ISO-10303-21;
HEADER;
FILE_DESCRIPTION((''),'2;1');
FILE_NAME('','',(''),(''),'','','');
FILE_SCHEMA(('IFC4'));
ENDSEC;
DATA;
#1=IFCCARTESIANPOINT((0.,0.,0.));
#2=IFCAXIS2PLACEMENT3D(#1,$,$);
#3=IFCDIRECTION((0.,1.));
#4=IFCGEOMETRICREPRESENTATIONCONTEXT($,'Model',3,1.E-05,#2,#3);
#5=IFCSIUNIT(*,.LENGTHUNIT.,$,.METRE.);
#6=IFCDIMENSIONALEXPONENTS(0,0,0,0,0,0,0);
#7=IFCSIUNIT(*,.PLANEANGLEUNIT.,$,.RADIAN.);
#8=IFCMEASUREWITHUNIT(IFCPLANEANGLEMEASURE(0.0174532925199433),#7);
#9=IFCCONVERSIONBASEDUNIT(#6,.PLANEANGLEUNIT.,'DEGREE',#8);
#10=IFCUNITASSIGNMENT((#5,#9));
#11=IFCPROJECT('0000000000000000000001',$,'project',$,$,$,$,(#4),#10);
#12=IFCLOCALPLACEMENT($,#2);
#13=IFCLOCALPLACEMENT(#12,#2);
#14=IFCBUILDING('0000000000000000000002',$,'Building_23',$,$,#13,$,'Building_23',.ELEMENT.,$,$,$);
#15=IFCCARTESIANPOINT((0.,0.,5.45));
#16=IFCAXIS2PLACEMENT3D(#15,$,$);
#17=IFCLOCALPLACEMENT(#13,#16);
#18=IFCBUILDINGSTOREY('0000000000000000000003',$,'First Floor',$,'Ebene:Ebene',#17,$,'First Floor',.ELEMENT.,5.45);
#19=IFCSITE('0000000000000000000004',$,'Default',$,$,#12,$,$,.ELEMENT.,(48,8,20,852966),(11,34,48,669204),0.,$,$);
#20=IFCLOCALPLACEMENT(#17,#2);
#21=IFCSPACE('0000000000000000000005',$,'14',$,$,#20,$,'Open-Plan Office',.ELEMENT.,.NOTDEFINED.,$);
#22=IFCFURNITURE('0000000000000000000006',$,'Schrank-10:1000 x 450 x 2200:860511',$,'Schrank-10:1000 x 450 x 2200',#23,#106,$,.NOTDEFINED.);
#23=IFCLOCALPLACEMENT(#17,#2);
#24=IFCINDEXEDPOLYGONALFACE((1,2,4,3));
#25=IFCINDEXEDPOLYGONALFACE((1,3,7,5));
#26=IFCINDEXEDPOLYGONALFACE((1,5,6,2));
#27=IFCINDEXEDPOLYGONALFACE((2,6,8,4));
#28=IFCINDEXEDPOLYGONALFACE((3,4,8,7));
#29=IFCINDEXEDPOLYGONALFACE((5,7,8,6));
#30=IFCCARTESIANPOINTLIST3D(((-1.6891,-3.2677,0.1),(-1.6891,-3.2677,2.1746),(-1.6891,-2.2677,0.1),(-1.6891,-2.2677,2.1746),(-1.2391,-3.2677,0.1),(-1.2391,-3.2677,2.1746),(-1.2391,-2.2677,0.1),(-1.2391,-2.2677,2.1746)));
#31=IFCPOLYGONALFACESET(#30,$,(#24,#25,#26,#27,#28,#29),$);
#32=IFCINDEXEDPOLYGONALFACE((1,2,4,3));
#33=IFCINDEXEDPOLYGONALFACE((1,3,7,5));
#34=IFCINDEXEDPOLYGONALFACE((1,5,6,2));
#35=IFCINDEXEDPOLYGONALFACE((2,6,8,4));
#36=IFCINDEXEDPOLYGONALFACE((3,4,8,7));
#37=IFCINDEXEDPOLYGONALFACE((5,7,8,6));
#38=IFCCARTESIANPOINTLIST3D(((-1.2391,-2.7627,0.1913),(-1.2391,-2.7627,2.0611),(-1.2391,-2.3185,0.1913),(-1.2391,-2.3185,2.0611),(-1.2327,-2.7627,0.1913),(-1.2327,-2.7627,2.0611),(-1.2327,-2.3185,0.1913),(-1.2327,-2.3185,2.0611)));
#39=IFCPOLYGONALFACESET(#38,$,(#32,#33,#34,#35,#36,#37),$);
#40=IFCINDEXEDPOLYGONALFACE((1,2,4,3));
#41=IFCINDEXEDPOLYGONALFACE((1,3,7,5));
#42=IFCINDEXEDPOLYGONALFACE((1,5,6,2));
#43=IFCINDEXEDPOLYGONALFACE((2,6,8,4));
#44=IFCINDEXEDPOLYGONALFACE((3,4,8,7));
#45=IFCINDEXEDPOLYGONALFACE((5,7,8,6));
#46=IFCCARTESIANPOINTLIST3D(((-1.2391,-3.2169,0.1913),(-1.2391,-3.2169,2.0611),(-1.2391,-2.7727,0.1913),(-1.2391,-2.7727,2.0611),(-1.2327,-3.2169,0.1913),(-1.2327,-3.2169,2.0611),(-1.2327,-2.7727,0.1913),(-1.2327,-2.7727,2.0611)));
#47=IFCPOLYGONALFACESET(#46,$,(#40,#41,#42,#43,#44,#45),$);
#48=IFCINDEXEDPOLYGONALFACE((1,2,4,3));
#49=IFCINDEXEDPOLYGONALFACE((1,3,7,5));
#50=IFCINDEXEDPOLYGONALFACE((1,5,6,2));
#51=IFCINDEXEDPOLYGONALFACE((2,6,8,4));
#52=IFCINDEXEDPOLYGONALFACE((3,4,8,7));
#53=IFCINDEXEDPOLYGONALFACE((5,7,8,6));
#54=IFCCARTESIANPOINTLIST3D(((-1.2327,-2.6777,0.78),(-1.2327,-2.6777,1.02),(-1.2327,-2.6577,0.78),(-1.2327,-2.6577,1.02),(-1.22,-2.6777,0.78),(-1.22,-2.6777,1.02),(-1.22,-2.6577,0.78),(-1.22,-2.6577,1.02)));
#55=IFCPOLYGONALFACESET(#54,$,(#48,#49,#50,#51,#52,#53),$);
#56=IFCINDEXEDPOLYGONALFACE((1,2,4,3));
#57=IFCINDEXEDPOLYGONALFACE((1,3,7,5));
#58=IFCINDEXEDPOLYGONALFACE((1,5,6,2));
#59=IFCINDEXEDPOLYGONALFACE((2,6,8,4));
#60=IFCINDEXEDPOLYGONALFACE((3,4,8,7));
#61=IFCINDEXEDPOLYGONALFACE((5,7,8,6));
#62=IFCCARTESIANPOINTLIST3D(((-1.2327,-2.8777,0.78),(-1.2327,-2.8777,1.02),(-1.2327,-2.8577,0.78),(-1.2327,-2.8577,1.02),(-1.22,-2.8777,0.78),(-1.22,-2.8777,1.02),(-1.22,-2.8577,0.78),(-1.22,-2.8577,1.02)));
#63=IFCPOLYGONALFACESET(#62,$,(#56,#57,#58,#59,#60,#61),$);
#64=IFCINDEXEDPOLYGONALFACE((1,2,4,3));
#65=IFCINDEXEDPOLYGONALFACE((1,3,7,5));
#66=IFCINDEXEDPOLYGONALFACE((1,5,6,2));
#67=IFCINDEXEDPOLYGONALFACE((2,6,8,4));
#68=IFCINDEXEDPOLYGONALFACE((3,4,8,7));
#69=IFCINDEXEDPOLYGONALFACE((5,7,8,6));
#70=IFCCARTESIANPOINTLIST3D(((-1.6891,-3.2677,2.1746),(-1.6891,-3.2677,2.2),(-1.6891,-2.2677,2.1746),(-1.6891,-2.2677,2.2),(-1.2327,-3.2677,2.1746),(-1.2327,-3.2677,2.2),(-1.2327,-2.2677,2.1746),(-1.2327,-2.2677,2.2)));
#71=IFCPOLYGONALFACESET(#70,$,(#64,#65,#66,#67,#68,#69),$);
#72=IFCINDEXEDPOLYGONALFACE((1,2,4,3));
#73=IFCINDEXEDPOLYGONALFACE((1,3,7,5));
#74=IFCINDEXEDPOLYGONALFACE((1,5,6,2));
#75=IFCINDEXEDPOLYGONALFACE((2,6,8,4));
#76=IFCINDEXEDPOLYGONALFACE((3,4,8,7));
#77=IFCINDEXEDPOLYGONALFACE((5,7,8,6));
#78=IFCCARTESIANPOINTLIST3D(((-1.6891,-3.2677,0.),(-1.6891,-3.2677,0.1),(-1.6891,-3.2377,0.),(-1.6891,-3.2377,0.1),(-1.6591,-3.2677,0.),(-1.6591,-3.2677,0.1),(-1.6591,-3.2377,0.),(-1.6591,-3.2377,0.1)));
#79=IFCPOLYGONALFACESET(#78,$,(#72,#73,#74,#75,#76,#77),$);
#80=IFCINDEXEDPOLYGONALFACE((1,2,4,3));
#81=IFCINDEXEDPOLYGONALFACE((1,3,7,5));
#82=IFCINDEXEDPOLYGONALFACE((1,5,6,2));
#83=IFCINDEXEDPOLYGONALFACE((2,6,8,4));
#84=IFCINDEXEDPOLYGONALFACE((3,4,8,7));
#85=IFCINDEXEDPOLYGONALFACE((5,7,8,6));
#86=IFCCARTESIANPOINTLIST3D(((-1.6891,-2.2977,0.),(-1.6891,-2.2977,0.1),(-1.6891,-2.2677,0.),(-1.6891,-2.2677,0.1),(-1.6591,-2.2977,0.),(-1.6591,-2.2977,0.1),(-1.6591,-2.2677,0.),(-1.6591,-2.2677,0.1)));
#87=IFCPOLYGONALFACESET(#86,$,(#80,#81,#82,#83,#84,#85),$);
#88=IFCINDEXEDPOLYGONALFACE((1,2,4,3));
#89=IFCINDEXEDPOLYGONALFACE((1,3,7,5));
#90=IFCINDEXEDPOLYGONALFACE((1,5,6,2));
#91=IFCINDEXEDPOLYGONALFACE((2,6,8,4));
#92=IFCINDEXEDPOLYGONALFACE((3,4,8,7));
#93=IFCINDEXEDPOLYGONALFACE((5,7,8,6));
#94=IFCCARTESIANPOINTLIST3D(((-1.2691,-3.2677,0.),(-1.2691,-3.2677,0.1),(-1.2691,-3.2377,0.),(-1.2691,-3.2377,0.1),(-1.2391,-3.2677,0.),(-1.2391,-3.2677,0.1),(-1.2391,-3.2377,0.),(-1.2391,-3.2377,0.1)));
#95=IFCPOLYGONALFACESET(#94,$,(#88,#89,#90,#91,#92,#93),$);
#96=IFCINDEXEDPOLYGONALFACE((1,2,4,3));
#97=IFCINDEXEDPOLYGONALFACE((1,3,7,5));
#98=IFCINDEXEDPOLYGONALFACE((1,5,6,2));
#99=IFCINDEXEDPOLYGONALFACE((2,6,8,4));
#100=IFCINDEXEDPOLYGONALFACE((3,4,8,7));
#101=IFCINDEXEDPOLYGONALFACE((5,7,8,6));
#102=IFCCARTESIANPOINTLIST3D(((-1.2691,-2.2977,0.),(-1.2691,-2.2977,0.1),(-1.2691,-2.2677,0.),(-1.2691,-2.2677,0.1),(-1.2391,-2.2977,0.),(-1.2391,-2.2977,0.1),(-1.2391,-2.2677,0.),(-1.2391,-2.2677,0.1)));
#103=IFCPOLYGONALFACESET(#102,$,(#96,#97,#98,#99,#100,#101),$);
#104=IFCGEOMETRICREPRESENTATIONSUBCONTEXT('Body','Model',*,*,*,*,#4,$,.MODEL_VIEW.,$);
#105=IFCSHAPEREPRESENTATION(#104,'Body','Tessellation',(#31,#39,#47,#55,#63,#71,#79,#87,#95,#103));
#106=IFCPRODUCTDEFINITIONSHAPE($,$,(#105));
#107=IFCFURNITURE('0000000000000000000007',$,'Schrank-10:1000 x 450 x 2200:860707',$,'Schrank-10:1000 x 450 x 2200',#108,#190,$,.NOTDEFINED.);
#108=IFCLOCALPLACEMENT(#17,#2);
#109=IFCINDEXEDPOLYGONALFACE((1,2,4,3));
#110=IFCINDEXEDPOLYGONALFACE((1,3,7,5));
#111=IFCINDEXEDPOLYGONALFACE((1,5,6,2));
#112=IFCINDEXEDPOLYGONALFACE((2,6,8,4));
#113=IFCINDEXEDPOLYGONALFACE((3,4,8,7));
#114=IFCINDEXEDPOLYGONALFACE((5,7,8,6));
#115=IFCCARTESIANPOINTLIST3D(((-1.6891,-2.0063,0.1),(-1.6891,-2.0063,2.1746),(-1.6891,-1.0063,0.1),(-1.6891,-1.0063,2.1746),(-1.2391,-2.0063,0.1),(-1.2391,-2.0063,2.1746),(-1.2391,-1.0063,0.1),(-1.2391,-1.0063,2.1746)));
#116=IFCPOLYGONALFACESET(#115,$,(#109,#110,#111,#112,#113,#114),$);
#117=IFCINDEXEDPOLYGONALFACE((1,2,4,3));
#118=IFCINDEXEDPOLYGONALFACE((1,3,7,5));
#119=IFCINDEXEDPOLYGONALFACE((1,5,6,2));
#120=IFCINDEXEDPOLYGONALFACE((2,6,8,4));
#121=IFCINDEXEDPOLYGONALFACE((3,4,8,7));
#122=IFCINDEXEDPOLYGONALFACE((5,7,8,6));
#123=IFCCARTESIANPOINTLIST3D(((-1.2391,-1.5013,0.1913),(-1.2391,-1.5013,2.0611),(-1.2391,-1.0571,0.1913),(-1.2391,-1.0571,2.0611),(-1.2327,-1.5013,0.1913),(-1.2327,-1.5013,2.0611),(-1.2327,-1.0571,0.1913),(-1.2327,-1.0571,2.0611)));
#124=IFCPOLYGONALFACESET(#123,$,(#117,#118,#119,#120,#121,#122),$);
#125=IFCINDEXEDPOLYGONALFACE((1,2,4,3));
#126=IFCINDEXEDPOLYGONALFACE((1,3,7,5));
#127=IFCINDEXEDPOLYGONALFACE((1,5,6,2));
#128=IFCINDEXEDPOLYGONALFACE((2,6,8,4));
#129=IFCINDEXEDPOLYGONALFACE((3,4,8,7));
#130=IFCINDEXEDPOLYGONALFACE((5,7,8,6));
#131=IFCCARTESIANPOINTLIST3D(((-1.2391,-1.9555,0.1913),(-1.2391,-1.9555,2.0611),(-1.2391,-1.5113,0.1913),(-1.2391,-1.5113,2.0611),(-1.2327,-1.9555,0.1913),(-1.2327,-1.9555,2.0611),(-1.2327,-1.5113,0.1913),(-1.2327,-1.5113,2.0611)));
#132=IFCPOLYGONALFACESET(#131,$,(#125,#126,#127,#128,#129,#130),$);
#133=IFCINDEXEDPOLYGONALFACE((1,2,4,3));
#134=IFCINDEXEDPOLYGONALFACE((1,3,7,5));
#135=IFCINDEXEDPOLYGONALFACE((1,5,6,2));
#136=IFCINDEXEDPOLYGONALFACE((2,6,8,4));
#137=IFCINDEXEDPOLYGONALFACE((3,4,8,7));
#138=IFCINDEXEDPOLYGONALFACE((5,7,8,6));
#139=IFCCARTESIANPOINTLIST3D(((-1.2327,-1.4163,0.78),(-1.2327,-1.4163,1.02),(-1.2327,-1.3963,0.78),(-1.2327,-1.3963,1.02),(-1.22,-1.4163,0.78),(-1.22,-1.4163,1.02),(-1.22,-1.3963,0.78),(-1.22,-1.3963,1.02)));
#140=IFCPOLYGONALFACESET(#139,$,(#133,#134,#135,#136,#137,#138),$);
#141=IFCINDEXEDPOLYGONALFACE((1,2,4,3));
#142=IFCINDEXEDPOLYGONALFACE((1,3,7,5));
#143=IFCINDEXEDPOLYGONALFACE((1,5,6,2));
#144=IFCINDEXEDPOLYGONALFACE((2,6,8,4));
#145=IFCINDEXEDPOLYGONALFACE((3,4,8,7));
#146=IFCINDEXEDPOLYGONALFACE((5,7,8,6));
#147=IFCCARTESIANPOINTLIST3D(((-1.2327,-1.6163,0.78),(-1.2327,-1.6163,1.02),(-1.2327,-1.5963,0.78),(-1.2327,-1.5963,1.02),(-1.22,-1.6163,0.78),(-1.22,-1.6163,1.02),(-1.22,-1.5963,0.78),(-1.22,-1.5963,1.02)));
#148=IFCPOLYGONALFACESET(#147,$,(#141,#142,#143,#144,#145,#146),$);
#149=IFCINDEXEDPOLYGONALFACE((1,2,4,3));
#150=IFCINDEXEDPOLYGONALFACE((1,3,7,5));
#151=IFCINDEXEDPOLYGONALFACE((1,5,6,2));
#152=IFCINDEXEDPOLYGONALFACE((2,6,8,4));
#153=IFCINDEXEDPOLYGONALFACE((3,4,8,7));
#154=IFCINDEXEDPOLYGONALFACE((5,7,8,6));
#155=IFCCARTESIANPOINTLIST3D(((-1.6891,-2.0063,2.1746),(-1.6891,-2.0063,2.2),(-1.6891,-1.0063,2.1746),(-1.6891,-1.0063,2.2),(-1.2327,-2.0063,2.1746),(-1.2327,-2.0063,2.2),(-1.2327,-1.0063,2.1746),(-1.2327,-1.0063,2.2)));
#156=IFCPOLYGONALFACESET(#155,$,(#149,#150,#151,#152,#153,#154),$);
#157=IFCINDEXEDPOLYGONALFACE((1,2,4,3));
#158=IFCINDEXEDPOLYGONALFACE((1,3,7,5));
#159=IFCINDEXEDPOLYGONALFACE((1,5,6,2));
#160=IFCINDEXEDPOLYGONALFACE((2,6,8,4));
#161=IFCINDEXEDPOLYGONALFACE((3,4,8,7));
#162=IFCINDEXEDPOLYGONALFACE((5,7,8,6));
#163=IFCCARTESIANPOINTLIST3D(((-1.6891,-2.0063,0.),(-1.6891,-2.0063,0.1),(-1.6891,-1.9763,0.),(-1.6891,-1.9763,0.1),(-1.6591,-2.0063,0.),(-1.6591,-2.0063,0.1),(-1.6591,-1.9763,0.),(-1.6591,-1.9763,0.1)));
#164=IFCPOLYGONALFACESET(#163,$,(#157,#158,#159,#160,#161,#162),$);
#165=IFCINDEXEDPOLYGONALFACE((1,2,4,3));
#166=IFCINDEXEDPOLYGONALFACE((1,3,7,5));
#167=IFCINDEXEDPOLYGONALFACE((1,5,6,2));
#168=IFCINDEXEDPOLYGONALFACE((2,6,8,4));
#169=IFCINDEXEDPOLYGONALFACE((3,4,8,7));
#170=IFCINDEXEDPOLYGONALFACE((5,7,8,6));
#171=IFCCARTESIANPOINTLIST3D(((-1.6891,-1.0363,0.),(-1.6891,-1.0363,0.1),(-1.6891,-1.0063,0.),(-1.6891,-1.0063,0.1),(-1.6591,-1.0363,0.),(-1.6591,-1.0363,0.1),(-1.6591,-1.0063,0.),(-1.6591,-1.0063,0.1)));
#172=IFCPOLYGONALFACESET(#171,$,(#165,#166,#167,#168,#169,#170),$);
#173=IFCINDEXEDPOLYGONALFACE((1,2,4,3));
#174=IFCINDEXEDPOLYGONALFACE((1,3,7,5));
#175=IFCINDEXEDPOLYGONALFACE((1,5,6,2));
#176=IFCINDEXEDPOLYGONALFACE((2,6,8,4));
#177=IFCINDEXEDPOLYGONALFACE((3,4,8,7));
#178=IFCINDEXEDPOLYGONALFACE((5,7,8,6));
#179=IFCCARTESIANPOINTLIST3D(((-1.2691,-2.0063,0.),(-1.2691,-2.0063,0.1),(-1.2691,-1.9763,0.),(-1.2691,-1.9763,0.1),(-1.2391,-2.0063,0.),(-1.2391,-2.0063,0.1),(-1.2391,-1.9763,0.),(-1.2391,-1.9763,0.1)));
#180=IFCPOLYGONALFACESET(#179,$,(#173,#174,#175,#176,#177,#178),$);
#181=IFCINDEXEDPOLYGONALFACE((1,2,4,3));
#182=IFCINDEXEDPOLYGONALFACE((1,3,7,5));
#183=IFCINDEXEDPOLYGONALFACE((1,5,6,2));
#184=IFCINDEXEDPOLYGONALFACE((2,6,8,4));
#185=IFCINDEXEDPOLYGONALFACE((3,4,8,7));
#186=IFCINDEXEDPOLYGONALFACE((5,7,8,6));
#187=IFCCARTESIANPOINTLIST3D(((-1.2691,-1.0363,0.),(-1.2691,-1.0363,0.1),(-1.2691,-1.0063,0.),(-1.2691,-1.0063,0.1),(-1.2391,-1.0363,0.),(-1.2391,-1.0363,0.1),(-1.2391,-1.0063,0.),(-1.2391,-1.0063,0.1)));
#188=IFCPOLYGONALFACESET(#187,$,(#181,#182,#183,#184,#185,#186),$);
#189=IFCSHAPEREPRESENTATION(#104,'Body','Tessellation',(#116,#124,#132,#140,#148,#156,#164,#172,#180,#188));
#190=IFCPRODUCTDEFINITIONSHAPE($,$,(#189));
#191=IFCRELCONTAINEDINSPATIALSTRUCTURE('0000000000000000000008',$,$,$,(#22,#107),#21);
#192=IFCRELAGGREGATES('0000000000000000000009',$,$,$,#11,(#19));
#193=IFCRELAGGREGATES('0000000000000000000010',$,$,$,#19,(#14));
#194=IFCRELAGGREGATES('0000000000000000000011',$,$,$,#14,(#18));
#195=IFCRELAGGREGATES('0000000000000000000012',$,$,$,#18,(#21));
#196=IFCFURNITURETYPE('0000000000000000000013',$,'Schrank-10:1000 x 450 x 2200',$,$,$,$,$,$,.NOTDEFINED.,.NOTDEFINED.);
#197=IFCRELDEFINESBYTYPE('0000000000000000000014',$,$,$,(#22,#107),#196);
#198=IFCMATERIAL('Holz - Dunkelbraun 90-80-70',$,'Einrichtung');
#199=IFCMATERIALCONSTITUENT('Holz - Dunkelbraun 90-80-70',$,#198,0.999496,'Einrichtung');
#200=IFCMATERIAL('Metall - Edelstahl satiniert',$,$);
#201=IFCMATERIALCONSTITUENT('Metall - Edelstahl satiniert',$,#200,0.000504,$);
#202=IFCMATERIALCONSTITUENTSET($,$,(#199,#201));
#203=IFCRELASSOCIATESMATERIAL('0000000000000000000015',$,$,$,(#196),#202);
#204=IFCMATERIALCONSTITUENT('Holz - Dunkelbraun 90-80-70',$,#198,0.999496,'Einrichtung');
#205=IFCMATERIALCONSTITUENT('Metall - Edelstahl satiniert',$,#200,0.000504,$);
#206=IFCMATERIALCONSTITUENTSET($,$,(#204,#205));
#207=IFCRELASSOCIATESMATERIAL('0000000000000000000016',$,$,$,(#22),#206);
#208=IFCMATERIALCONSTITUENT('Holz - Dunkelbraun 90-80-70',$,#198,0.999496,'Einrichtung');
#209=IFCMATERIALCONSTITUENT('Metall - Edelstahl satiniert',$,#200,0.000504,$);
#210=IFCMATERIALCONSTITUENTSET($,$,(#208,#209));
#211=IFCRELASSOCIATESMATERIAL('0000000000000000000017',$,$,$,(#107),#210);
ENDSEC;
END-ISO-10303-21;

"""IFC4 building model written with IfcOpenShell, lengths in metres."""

from ifc_helpers import new_model, entity, si_unit, converted_unit, direction, frame, origin, place, context, subcontext, project, spatial, indexed_curve, outline, extrude, source, transform, mapped, material, constituent, constituent_set, type_object, type_shapes, element, save


model = new_model("IFC4")

# Units and contexts
model_context = context("Model", 3, precision=1e-05, world=origin(), true_north=direction((0.0, 1.0)))
body_context = subcontext(model_context, "Body", "Model", "MODEL_VIEW")
ifc_project = project(units=[si_unit("LENGTHUNIT", "METRE"), converted_unit("PLANEANGLEUNIT", "DEGREE", entity("IfcPlaneAngleMeasure", 0.0174532925199433), si_unit("PLANEANGLEUNIT", "RADIAN"), dimensions=[0, 0, 0, 0, 0, 0, 0])], contexts=[model_context])

# Site, building, storey
site_placement = place(None, origin())
site = spatial("IfcSite", under=ifc_project, at=site_placement, Name="Default", CompositionType="ELEMENT", RefLatitude=(48, 8, 20, 852966), RefLongitude=(11, 34, 48, 669204), RefElevation=0.0)
building_placement = place(site_placement, origin())
building = spatial("IfcBuilding", under=site, at=building_placement, Name="Building_23", LongName="Building_23", CompositionType="ELEMENT")
storey_placement = place(building_placement, frame((0.0, 0.0, 5.45)))
storey = spatial("IfcBuildingStorey", under=building, at=storey_placement, Name="First Floor", ObjectType="Ebene:Ebene", LongName="First Floor", CompositionType="ELEMENT", Elevation=5.45)

# Shared definitions
ifc_material_1 = material(Name="Holz - Dunkelbraun 90-80-70", Category="Einrichtung")
ifc_material_2 = material(Name="Metall - Edelstahl satiniert")
ifc_constituent_1 = constituent(ifc_material_1, Name="Holz - Dunkelbraun 90-80-70", Category="Einrichtung", fraction=0.999496)
ifc_constituent_2 = constituent(ifc_material_2, Name="Metall - Edelstahl satiniert", fraction=0.000504)
ifc_constituent_set_1 = constituent_set(constituents=[ifc_constituent_1, ifc_constituent_2])
furniture_type = type_object("IfcFurnitureType", Name="Schrank-10:1000 x 450 x 2200", AssemblyPlace="NOTDEFINED", PredefinedType="NOTDEFINED", material=ifc_constituent_set_1)
shared_shape_1 = source(origin(), body_context, "Body", "SweptSolid", [
    extrude(outline(indexed_curve([(-0.225, -0.5), (0.225, -0.5), (0.225, 0.5), (-0.225, 0.5), (-0.225, -0.5)], self_intersect=False)), frame((-0.2692, -0.3632, 0.1), z_axis=(0.0, 0.0, 1.0), x_axis=(0.0, 1.0, 0.0)), (0.0, 0.0, 1.0), 2.0746),
    extrude(outline(indexed_curve([(-0.0032, -0.2221), (0.0032, -0.2221), (0.0032, 0.2221), (-0.0032, 0.2221), (-0.0032, -0.2221)], self_intersect=False)), frame((-0.0421, -0.5913, 0.1913), z_axis=(0.0, 0.0, 1.0), x_axis=(0.0, 1.0, 0.0)), (0.0, 0.0, 1.0), 1.8698),
    extrude(outline(indexed_curve([(-0.0032, -0.2221), (0.0032, -0.2221), (0.0032, 0.2221), (-0.0032, 0.2221), (-0.0032, -0.2221)], self_intersect=False)), frame((-0.4963, -0.5913, 0.1913), z_axis=(0.0, 0.0, 1.0), x_axis=(0.0, 1.0, 0.0)), (0.0, 0.0, 1.0), 1.8698),
    extrude(outline(indexed_curve([(-0.0063, -0.01), (0.0063, -0.01), (0.0063, 0.01), (-0.0063, 0.01), (-0.0063, -0.01)], self_intersect=False)), frame((-0.1692, -0.6009, 0.78), z_axis=(0.0, 0.0, 1.0), x_axis=(0.0, 1.0, 0.0)), (0.0, 0.0, 1.0), 0.24),
    extrude(outline(indexed_curve([(-0.0063, -0.01), (0.0063, -0.01), (0.0063, 0.01), (-0.0063, 0.01), (-0.0063, -0.01)], self_intersect=False)), frame((-0.3692, -0.6009, 0.78), z_axis=(0.0, 0.0, 1.0), x_axis=(0.0, 1.0, 0.0)), (0.0, 0.0, 1.0), 0.24),
    extrude(outline(indexed_curve([(-0.5, -0.2282), (0.5, -0.2282), (0.5, 0.2282), (-0.5, 0.2282), (-0.5, -0.2282)], self_intersect=False)), frame((-0.2692, -0.3663, 2.1746), z_axis=(0.0, 0.0, 1.0), x_axis=(-1.0, 0.0, 0.0)), (0.0, 0.0, 1.0), 0.0254),
    extrude(outline(indexed_curve([(-0.015, -0.015), (0.015, -0.015), (0.015, 0.015), (-0.015, 0.015), (-0.015, -0.015)], self_intersect=False)), frame((-0.7542, -0.1532, 0.0), z_axis=(0.0, 0.0, 1.0), x_axis=(-1.0, 0.0, 0.0)), (0.0, 0.0, 1.0), 0.1),
    extrude(outline(indexed_curve([(-0.015, -0.015), (0.015, -0.015), (0.015, 0.015), (-0.015, 0.015), (-0.015, -0.015)], self_intersect=False)), frame((0.2158, -0.1532, 0.0), z_axis=(0.0, 0.0, 1.0), x_axis=(0.0, -1.0, 0.0)), (0.0, 0.0, 1.0), 0.1),
    extrude(outline(indexed_curve([(-0.015, -0.015), (0.015, -0.015), (0.015, 0.015), (-0.015, 0.015), (-0.015, -0.015)], self_intersect=False)), frame((-0.7542, -0.5732, 0.0), z_axis=(0.0, 0.0, 1.0), x_axis=(0.0, 1.0, 0.0)), (0.0, 0.0, 1.0), 0.1),
    extrude(outline(indexed_curve([(-0.015, -0.015), (0.015, -0.015), (0.015, 0.015), (-0.015, 0.015), (-0.015, -0.015)], self_intersect=False)), frame((0.2158, -0.5732, 0.0)), (0.0, 0.0, 1.0), 0.1),
])
type_shapes(furniture_type, [shared_shape_1])

# Shared definitions
space_1_placement = place(storey_placement, origin())
space_1 = spatial("IfcSpace", under=storey, at=space_1_placement, Name="14", LongName="Open-Plan Office", CompositionType="ELEMENT", PredefinedType="NOTDEFINED")

# Furniture
ifc_constituent_3 = constituent(ifc_material_1, Name="Holz - Dunkelbraun 90-80-70", Category="Einrichtung", fraction=0.999496)
ifc_constituent_4 = constituent(ifc_material_2, Name="Metall - Edelstahl satiniert", fraction=0.000504)
ifc_constituent_set_2 = constituent_set(constituents=[ifc_constituent_3, ifc_constituent_4])
furniture_1_placement = place(space_1_placement, frame((-1.8272, -2.4985, 0.0), z_axis=(0.0, 0.0, 1.0), x_axis=(0.0, 1.0, 0.0)))
element("IfcFurniture", 1, at=furniture_1_placement, inside=space_1, type_object=furniture_type, material=ifc_constituent_set_2, Name="Schrank-10:1000 x 450 x 2200:860511", ObjectType="Schrank-10:1000 x 450 x 2200", PredefinedType="NOTDEFINED", context=body_context, shape_type="MappedRepresentation", body=[
    mapped(shared_shape_1, transform((0.0, 0.0, 0.0), scale=1.0)),
])
ifc_constituent_5 = constituent(ifc_material_1, Name="Holz - Dunkelbraun 90-80-70", Category="Einrichtung", fraction=0.999496)
ifc_constituent_6 = constituent(ifc_material_2, Name="Metall - Edelstahl satiniert", fraction=0.000504)
ifc_constituent_set_3 = constituent_set(constituents=[ifc_constituent_5, ifc_constituent_6])
furniture_2_placement = place(space_1_placement, frame((-1.8272, -1.2371, 0.0), z_axis=(0.0, 0.0, 1.0), x_axis=(0.0, 1.0, 0.0)))
element("IfcFurniture", 2, at=furniture_2_placement, inside=space_1, type_object=furniture_type, material=ifc_constituent_set_3, Name="Schrank-10:1000 x 450 x 2200:860707", ObjectType="Schrank-10:1000 x 450 x 2200", PredefinedType="NOTDEFINED", context=body_context, shape_type="MappedRepresentation", body=[
    mapped(shared_shape_1, transform((0.0, 0.0, 0.0), scale=1.0)),
])

save(model, "model.ifc")
